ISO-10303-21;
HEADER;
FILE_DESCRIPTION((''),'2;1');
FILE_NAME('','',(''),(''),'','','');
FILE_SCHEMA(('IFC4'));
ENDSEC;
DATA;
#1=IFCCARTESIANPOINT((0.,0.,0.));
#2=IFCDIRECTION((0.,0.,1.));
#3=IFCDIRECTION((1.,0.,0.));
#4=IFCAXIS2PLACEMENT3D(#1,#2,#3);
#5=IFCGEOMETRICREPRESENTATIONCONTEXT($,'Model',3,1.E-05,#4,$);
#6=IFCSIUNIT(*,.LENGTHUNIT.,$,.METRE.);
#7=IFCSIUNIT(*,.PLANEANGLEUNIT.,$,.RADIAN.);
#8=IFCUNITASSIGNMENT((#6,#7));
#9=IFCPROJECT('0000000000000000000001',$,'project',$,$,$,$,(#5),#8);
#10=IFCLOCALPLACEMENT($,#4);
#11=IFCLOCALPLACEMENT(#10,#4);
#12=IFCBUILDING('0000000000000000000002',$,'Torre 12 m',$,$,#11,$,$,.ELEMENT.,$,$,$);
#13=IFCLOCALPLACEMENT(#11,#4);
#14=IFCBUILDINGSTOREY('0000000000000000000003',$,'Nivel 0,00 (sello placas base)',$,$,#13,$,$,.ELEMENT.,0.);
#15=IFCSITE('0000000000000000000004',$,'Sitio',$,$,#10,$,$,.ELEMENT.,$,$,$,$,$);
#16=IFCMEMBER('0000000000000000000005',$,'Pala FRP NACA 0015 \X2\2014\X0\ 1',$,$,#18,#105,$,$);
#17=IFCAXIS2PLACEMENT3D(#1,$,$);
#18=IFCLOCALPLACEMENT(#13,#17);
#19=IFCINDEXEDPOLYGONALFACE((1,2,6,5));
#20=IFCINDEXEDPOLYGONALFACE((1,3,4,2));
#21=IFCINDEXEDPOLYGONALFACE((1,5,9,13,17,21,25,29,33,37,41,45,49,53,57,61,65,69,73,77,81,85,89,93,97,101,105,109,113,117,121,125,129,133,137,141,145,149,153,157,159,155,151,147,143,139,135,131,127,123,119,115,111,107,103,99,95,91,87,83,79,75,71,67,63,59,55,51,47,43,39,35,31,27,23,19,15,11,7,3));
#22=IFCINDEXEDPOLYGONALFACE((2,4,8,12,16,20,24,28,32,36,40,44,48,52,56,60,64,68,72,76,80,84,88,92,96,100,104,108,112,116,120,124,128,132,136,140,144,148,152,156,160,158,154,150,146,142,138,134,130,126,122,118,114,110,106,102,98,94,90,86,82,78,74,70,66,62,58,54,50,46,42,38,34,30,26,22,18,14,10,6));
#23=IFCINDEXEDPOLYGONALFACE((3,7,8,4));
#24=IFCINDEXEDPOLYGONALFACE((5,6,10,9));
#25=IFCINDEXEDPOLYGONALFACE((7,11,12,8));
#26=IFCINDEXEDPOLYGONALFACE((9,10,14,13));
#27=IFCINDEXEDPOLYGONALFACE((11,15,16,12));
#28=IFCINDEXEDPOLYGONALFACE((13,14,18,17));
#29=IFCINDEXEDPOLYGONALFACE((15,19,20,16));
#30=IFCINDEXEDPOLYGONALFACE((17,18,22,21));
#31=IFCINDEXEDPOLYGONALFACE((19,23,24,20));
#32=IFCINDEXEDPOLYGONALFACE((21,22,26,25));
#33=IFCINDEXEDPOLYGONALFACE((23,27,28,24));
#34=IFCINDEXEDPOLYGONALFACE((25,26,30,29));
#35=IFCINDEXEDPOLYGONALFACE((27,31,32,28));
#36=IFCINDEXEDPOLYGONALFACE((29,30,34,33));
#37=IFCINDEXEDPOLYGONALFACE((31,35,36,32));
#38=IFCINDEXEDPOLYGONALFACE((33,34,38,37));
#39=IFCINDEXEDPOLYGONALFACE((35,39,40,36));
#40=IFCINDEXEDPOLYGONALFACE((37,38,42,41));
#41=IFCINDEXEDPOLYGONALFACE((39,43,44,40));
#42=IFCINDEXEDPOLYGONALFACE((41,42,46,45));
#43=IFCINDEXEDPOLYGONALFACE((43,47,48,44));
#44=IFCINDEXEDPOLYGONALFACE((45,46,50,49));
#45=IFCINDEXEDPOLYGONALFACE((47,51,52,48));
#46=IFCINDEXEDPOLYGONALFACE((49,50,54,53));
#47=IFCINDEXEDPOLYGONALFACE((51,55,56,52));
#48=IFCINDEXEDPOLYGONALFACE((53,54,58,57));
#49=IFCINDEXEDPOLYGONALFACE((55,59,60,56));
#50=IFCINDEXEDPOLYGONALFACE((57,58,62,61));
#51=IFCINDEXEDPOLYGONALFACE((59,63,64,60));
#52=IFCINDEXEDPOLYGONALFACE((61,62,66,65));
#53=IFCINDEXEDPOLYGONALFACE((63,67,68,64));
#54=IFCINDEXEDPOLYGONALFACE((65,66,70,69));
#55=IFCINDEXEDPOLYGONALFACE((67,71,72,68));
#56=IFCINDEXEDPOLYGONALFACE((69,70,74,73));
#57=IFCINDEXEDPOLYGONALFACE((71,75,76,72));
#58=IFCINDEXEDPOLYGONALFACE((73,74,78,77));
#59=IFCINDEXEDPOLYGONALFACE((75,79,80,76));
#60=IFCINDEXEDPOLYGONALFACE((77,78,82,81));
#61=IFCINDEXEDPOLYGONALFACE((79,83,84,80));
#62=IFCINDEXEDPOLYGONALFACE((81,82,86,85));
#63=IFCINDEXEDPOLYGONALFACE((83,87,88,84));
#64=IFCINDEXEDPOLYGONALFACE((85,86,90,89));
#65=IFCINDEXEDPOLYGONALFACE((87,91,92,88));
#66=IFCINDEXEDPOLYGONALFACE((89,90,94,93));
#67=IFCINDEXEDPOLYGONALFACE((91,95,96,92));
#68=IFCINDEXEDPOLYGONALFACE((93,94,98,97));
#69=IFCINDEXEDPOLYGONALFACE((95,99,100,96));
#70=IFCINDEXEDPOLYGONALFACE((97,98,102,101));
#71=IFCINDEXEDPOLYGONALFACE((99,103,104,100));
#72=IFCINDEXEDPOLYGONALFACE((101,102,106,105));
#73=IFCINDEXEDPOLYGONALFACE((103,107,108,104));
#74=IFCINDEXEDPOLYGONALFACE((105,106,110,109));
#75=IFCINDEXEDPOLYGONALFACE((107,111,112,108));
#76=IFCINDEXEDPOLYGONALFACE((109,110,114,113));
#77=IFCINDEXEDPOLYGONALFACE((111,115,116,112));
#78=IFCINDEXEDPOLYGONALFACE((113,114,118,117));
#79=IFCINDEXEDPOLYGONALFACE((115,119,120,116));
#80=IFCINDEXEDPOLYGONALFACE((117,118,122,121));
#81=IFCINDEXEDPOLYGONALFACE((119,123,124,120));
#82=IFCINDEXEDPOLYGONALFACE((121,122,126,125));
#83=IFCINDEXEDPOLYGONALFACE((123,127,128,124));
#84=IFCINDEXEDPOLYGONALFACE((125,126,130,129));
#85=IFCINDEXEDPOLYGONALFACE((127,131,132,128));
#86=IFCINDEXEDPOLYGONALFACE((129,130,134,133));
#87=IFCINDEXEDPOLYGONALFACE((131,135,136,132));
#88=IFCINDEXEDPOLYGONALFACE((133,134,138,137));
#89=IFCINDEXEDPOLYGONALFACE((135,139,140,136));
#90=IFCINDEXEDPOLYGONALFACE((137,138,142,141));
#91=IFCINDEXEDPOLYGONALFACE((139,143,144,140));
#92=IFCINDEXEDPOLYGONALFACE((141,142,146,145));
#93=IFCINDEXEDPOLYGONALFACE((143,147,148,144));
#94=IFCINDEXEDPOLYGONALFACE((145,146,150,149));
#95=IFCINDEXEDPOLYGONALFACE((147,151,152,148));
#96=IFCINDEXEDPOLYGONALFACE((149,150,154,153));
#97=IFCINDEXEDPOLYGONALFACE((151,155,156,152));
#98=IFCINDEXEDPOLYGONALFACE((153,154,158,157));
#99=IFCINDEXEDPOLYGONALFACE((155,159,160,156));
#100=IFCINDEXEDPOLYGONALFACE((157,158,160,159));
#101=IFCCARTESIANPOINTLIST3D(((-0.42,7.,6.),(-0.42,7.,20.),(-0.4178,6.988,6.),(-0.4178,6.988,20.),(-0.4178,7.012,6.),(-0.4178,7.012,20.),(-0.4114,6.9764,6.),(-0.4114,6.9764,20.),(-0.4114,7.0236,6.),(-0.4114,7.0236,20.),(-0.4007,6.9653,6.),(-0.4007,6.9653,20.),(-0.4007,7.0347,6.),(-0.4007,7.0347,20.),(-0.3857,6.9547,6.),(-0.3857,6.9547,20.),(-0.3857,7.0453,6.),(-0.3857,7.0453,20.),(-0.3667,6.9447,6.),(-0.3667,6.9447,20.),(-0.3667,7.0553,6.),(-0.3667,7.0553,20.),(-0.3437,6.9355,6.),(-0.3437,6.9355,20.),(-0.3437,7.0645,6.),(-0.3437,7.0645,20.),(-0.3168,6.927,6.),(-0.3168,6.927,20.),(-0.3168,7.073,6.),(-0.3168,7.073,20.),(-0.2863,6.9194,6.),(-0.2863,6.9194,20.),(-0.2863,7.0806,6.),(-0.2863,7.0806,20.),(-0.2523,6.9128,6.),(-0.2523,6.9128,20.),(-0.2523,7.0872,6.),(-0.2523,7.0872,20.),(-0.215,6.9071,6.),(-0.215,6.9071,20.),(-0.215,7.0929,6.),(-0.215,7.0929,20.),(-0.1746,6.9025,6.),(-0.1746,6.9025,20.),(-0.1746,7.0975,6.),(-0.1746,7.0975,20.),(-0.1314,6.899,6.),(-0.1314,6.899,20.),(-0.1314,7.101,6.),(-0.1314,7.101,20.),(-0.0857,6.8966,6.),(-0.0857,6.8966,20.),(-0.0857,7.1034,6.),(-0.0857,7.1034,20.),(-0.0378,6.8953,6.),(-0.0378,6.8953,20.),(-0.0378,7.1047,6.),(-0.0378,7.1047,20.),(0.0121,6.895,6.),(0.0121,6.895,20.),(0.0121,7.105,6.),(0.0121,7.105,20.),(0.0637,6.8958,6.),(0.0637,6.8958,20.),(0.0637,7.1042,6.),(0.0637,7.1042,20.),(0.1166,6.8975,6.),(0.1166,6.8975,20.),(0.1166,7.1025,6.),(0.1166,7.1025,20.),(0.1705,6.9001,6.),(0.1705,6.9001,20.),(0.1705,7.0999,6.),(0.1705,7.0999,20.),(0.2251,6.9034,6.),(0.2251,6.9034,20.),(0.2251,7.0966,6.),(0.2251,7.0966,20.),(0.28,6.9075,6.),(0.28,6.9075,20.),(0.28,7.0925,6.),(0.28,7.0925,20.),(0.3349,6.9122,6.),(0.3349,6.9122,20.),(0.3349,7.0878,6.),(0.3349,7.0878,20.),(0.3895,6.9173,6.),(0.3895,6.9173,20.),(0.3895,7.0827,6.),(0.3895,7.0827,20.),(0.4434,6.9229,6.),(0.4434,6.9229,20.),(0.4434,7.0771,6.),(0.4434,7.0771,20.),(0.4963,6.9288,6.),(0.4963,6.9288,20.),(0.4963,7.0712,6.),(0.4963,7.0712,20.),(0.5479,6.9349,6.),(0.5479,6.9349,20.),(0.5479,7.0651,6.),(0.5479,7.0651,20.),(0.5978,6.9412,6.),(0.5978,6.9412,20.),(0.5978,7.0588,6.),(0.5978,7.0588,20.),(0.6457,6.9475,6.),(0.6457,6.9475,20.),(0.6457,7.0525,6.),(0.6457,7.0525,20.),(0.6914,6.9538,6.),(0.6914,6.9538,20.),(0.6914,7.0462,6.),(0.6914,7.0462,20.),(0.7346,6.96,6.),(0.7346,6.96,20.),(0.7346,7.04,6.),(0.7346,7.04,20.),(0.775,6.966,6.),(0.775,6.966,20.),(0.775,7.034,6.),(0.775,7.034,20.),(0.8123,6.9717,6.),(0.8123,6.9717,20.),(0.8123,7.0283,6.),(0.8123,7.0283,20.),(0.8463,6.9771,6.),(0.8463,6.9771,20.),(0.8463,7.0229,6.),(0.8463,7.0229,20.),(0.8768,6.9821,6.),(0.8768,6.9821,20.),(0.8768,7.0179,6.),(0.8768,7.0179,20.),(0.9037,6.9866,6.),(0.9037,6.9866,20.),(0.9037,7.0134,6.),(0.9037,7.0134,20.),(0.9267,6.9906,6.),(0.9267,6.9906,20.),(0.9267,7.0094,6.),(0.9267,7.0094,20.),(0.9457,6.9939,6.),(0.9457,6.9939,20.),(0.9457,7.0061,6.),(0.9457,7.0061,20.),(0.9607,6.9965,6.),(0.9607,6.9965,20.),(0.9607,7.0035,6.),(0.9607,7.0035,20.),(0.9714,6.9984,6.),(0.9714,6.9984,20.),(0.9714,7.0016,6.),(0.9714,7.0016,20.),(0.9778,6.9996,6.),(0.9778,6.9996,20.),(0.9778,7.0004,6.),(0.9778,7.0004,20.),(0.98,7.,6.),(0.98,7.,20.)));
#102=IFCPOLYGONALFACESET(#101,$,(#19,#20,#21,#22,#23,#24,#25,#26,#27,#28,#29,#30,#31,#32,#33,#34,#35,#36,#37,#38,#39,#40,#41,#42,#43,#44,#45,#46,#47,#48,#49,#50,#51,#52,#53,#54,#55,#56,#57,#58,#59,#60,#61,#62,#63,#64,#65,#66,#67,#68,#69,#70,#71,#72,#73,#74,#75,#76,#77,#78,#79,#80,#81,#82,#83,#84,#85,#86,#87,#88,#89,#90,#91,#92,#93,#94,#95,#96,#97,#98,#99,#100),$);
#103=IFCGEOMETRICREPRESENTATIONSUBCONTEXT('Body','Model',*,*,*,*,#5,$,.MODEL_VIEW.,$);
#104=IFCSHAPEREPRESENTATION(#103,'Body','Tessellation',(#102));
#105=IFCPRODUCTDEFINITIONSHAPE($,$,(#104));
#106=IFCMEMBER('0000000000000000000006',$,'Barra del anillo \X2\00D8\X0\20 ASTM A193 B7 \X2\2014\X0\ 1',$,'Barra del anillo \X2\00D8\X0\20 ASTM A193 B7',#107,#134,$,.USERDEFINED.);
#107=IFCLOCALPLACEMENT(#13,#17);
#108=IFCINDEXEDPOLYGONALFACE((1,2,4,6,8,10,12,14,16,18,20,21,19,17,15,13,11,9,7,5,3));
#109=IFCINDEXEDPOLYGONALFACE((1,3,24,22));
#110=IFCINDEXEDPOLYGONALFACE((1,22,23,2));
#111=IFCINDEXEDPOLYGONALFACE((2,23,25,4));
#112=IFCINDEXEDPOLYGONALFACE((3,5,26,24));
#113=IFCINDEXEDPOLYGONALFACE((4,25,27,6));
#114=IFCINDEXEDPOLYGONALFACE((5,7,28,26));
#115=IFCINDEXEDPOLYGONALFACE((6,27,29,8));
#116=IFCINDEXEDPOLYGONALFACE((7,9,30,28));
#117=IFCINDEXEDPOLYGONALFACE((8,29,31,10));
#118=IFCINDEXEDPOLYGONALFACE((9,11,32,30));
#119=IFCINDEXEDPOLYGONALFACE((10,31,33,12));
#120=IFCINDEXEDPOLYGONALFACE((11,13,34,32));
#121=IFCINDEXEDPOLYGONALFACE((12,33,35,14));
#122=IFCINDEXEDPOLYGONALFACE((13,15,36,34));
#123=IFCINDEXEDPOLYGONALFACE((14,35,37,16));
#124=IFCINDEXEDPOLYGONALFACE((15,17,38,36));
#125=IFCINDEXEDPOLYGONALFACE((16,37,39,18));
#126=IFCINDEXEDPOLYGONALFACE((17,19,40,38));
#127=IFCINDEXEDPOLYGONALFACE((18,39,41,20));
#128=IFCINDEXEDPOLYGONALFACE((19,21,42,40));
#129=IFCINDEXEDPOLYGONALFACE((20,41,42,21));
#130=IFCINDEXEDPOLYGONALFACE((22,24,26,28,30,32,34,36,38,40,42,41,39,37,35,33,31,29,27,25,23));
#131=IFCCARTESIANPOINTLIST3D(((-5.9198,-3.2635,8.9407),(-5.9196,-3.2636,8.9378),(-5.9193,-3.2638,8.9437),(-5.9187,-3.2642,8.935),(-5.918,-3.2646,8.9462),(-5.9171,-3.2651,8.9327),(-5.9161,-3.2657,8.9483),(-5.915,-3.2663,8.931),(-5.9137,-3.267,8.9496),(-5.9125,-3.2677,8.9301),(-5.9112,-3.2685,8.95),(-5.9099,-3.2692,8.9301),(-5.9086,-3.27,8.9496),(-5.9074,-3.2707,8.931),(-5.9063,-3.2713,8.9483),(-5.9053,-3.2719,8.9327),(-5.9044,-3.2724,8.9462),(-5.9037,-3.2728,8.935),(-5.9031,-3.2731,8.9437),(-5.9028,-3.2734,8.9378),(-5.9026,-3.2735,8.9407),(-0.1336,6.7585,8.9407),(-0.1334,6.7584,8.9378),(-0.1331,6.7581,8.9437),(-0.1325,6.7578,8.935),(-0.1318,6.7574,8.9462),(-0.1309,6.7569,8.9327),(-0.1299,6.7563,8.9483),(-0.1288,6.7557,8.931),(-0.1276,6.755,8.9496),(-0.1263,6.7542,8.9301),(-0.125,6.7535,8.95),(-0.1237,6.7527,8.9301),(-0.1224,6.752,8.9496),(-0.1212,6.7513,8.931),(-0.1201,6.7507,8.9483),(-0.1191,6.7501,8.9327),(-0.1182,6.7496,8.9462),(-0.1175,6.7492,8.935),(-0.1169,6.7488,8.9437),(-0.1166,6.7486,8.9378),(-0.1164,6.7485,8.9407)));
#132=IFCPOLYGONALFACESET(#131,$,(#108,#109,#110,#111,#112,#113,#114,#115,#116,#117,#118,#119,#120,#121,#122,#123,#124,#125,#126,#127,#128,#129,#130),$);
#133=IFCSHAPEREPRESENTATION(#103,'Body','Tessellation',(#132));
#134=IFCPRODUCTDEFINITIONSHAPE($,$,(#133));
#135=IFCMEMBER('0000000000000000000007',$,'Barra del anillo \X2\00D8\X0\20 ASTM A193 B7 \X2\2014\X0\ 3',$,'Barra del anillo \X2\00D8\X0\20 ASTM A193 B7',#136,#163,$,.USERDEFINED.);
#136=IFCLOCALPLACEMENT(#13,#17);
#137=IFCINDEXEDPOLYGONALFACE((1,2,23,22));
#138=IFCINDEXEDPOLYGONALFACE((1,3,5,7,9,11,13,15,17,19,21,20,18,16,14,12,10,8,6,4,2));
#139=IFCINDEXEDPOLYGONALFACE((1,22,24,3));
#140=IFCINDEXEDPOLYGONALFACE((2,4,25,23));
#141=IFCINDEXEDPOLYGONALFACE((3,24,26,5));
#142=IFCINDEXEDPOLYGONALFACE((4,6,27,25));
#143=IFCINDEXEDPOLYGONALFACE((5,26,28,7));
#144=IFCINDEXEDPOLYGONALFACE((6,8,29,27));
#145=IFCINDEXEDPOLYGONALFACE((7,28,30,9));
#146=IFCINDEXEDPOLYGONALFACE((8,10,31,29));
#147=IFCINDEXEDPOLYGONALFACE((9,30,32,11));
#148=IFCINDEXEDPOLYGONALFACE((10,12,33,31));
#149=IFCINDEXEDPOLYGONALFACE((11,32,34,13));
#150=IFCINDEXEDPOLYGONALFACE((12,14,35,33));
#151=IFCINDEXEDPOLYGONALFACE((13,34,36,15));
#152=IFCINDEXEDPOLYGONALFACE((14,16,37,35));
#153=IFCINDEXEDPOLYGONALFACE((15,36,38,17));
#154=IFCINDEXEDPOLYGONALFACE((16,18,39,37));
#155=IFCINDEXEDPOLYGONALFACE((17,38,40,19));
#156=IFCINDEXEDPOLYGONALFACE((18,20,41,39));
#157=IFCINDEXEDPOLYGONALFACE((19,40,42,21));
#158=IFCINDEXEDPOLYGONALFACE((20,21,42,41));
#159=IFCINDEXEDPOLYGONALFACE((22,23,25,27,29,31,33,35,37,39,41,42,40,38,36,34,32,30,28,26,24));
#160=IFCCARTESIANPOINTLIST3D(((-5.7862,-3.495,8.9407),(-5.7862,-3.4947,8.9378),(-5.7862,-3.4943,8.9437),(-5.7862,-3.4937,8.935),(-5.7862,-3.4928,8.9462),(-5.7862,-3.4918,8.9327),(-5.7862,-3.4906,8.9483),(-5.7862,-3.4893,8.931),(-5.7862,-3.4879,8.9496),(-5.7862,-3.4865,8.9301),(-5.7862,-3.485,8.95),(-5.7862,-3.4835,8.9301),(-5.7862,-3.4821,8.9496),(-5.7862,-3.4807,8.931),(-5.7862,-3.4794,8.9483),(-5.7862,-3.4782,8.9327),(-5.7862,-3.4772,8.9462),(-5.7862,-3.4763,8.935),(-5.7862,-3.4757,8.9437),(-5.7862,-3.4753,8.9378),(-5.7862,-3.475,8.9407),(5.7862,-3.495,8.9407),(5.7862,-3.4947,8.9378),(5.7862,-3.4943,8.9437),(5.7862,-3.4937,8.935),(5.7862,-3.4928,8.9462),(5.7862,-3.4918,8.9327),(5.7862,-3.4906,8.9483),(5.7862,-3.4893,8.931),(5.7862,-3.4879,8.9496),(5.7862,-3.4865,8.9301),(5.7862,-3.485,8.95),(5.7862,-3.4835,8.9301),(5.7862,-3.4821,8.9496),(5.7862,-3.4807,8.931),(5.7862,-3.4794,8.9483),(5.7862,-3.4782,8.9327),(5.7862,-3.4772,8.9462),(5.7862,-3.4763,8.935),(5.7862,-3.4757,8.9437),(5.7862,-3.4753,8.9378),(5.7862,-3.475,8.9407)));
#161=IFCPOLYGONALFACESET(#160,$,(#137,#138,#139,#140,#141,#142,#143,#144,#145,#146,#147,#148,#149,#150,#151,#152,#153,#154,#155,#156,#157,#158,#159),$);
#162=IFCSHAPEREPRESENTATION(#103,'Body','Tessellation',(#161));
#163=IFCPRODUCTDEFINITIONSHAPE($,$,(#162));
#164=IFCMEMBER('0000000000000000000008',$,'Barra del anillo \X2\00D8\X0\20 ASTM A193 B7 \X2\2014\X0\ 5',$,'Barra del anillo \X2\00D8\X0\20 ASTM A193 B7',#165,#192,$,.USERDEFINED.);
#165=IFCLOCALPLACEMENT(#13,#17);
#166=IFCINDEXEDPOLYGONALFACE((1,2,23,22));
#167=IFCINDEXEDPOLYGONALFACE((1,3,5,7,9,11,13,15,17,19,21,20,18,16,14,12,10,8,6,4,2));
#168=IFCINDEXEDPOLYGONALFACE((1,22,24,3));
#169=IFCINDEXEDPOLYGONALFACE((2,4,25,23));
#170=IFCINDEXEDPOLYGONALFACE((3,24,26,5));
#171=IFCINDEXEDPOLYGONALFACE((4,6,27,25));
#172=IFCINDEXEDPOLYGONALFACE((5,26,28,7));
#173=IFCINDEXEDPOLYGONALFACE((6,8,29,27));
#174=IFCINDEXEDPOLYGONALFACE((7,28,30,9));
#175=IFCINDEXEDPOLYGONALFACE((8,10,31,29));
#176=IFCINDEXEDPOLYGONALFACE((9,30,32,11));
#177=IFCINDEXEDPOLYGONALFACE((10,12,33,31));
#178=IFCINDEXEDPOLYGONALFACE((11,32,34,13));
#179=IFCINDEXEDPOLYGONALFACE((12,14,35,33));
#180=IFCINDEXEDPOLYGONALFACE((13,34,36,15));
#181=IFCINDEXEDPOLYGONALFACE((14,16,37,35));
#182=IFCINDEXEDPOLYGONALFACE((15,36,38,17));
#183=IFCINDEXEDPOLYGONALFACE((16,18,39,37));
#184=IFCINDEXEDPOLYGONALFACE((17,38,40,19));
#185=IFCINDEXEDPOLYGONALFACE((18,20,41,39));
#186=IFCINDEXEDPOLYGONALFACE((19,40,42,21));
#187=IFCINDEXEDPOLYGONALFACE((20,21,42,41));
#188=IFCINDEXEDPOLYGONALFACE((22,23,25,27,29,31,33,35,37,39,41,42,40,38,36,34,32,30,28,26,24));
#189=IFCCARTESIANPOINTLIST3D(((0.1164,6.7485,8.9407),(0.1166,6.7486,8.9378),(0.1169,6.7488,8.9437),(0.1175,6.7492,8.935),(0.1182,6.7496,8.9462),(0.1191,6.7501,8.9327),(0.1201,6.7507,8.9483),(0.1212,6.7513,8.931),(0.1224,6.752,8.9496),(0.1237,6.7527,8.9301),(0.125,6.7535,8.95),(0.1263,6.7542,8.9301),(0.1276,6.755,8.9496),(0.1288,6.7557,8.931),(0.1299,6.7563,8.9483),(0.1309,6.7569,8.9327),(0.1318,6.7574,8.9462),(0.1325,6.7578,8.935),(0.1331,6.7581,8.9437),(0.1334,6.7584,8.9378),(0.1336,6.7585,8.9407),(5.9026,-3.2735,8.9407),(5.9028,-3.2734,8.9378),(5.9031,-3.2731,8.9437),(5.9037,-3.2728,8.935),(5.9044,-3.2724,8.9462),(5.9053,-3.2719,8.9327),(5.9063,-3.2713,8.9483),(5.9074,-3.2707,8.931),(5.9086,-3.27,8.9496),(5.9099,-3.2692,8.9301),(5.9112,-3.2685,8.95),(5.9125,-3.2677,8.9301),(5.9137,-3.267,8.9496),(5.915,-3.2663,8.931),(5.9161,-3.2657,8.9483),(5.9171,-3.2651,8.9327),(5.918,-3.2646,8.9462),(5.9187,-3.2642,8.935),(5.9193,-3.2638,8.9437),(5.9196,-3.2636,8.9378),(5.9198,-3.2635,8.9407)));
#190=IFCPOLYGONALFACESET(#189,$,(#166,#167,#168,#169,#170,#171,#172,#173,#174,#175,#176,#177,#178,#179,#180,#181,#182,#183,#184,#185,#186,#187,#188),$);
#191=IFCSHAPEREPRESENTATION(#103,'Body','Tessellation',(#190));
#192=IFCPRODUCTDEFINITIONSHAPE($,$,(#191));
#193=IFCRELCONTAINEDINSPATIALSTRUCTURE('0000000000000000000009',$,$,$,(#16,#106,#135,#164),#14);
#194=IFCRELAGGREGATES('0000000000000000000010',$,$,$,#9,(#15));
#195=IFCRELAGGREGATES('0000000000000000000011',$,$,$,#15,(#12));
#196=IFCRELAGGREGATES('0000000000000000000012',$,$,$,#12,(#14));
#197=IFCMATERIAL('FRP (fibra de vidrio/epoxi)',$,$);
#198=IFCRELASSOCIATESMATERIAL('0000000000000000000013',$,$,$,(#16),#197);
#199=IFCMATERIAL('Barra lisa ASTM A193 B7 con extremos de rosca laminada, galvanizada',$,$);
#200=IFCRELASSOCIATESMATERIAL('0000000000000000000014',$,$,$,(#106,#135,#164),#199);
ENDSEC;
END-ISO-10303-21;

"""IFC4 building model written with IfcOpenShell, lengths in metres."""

from ifc_helpers import new_model, si_unit, frame, origin, origin_with_axes, origin_2d, place, context, subcontext, project, spatial, polyline, circle, outline, extrude, material, element, save


model = new_model("IFC4")

# Units and contexts
model_context = context("Model", 3, precision=1e-05, world=origin_with_axes())
body_context = subcontext(model_context, "Body", "Model", "MODEL_VIEW")
ifc_project = project(units=[si_unit("LENGTHUNIT", "METRE"), si_unit("PLANEANGLEUNIT", "RADIAN")], contexts=[model_context])

# Site, building, storey
site_placement = place(None, origin_with_axes())
site = spatial("IfcSite", under=ifc_project, at=site_placement, Name="Sitio", CompositionType="ELEMENT")
building_placement = place(site_placement, origin_with_axes())
building = spatial("IfcBuilding", under=site, at=building_placement, Name="Torre 12 m", CompositionType="ELEMENT")
storey_placement = place(building_placement, origin_with_axes())
storey = spatial("IfcBuildingStorey", under=building, at=storey_placement, Name="Nivel 0,00 (sello placas base)", CompositionType="ELEMENT", Elevation=0.0)

# Members
ifc_material_1 = material(Name="FRP (fibra de vidrio/epoxi)")
member_1_placement = place(storey_placement, frame((0.0, 7.0, 6.0), z_axis=(0.0, 0.0, 1.0), x_axis=(-1.0, 0.0, 0.0)))
element("IfcMember", 1, at=member_1_placement, inside=storey, material=ifc_material_1, Name="Pala FRP NACA 0015 — 1", context=body_context, shape_type="SweptSolid", body=[
    extrude(outline(polyline([(0.42, 0.0), (0.4178, 0.012), (0.4114, 0.0236), (0.4007, 0.0347), (0.3857, 0.0453), (0.3667, 0.0553), (0.3437, 0.0645), (0.3168, 0.073), (0.2863, 0.0806), (0.2523, 0.0872), (0.215, 0.0929), (0.1746, 0.0975), (0.1314, 0.101), (0.0857, 0.1034), (0.0378, 0.1047), (-0.0121, 0.105), (-0.0637, 0.1042), (-0.1166, 0.1025), (-0.1705, 0.0999), (-0.2251, 0.0966), (-0.28, 0.0925), (-0.3349, 0.0878), (-0.3895, 0.0827), (-0.4434, 0.0771), (-0.4963, 0.0712), (-0.5479, 0.0651), (-0.5978, 0.0588), (-0.6457, 0.0525), (-0.6914, 0.0462), (-0.7346, 0.04), (-0.775, 0.034), (-0.8123, 0.0283), (-0.8463, 0.0229), (-0.8768, 0.0179), (-0.9037, 0.0134), (-0.9267, 0.0094), (-0.9457, 0.0061), (-0.9607, 0.0035), (-0.9714, 0.0016), (-0.9778, 0.0004), (-0.98, 0.0), (-0.9778, -0.0004), (-0.9714, -0.0016), (-0.9607, -0.0035), (-0.9457, -0.0061), (-0.9267, -0.0094), (-0.9037, -0.0134), (-0.8768, -0.0179), (-0.8463, -0.0229), (-0.8123, -0.0283), (-0.775, -0.034), (-0.7346, -0.04), (-0.6914, -0.0462), (-0.6457, -0.0525), (-0.5978, -0.0588), (-0.5479, -0.0651), (-0.4963, -0.0712), (-0.4434, -0.0771), (-0.3895, -0.0827), (-0.3349, -0.0878), (-0.28, -0.0925), (-0.2251, -0.0966), (-0.1705, -0.0999), (-0.1166, -0.1025), (-0.0637, -0.1042), (-0.0121, -0.105), (0.0378, -0.1047), (0.0857, -0.1034), (0.1314, -0.101), (0.1746, -0.0975), (0.215, -0.0929), (0.2523, -0.0872), (0.2863, -0.0806), (0.3168, -0.073), (0.3437, -0.0645), (0.3667, -0.0553), (0.3857, -0.0453), (0.4007, -0.0347), (0.4114, -0.0236), (0.4178, -0.012), (0.42, 0.0)])), origin(), (0.0, 0.0, 1.0), 14.0),
])
ifc_material_2 = material(Name="Barra lisa ASTM A193 B7 con extremos de rosca laminada, galvanizada")
for number, where, z_axis, x_axis, name in (
    (2, (-0.125, 6.7535, 8.94), (-0.5, -0.866025, 0.0), (0.0, 0.0, 1.0), "Barra del anillo Ø20 ASTM A193 B7 — 1"),
    (3, (-5.7862, -3.485, 8.94), (1.0, 0.0, 0.0), (0.0, 0.0, 1.0), "Barra del anillo Ø20 ASTM A193 B7 — 3"),
    (4, (5.9112, -3.2685, 8.94), (-0.5, 0.866025, 0.0), (0.0, 0.0, 1.0), "Barra del anillo Ø20 ASTM A193 B7 — 5"),
):
    element("IfcMember", number, at=place(storey_placement, frame(where, z_axis=z_axis, x_axis=x_axis)), inside=storey, material=ifc_material_2, Name=name, ObjectType="Barra del anillo Ø20 ASTM A193 B7", PredefinedType="USERDEFINED", context=body_context, shape_type="SweptSolid", body=[
        extrude(circle(Radius=0.01, at=origin_2d()), origin(), (0.0, 0.0, 1.0), 11.5724),
    ])

save(model, "model.ifc")
